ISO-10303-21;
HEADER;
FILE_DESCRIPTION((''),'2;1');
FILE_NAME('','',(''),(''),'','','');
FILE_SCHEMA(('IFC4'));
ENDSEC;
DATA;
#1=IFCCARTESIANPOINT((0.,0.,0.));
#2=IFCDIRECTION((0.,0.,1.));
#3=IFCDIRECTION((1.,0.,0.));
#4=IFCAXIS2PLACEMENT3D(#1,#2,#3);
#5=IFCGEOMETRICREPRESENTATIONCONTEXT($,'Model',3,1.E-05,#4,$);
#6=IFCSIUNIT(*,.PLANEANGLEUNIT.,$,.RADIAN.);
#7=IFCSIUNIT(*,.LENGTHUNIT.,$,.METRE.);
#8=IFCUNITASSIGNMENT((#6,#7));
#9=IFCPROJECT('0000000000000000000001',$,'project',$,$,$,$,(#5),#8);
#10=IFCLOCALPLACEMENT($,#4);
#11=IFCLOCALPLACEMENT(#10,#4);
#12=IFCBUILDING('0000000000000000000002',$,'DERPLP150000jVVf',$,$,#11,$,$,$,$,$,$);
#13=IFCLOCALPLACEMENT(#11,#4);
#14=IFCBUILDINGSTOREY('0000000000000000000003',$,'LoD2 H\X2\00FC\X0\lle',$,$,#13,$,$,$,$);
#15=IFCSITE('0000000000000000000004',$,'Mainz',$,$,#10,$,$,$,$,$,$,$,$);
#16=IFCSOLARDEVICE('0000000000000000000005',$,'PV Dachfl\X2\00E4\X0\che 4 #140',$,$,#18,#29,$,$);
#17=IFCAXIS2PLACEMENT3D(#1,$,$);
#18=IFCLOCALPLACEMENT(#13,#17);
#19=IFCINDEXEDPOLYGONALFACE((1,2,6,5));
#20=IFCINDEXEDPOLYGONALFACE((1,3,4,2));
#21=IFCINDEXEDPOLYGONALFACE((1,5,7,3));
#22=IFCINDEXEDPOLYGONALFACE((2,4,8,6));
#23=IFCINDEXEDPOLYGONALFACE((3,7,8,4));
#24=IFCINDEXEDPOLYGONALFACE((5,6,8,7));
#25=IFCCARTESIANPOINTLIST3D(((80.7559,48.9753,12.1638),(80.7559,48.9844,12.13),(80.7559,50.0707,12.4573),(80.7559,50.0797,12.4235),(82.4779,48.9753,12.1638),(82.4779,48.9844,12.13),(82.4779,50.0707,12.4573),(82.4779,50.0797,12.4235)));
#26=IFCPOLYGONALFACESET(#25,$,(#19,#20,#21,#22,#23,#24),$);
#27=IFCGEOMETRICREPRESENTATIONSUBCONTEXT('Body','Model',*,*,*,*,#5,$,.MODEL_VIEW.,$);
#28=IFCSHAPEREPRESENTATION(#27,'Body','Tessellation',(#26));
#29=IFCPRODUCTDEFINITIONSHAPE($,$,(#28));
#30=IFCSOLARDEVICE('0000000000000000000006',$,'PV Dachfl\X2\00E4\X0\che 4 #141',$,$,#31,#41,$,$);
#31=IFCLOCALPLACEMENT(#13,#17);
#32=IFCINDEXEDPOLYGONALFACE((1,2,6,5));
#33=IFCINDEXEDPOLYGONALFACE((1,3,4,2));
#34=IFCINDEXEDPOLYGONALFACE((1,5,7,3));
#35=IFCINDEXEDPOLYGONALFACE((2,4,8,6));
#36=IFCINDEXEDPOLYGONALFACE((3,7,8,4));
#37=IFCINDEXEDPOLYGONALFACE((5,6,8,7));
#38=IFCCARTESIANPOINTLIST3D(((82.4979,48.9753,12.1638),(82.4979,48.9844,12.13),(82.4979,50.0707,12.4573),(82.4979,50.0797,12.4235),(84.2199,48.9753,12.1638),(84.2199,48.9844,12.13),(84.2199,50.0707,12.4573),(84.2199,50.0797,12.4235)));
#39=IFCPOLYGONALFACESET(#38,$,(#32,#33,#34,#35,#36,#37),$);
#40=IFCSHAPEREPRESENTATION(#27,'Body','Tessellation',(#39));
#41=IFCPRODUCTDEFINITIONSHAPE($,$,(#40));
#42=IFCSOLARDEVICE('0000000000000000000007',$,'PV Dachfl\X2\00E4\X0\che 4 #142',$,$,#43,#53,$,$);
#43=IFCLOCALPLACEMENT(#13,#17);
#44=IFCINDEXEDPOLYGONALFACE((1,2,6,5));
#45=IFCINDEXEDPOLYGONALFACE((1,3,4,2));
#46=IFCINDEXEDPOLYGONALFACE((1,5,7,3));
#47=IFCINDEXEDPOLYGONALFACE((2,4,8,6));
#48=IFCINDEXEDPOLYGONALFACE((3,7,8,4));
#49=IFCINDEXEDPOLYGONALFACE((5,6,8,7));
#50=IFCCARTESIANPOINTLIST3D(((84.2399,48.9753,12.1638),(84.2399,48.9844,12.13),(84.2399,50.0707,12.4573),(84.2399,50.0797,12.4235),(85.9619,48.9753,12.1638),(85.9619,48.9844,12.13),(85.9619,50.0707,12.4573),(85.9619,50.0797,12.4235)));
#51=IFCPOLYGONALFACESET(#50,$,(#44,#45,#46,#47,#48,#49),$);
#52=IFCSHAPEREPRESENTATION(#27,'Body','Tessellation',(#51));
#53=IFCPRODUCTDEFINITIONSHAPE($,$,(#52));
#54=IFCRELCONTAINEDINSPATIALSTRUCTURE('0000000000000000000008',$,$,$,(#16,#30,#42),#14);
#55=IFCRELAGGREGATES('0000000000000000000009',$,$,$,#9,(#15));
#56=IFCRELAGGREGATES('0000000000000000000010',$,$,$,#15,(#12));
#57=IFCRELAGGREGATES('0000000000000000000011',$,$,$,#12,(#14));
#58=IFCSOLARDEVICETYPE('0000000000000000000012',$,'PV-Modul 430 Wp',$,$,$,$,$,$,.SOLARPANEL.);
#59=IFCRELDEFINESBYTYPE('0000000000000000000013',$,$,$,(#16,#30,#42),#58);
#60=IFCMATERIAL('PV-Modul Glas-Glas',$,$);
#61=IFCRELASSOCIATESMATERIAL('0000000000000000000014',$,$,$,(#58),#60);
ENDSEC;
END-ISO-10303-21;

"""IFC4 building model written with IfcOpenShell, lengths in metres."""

from ifc_helpers import new_model, si_unit, frame, frame_2d, origin, origin_with_axes, place, context, subcontext, project, spatial, rectangle, extrude, source, transform, mapped, material, type_object, type_shapes, element, save


model = new_model("IFC4")

# Units and contexts
model_context = context("Model", 3, precision=1e-05, world=origin_with_axes())
body_context = subcontext(model_context, "Body", "Model", "MODEL_VIEW")
ifc_project = project(units=[si_unit("PLANEANGLEUNIT", "RADIAN"), si_unit("LENGTHUNIT", "METRE")], contexts=[model_context])

# Site, building, storey
site_placement = place(None, origin_with_axes())
site = spatial("IfcSite", under=ifc_project, at=site_placement, Name="Mainz")
building_placement = place(site_placement, origin_with_axes())
building = spatial("IfcBuilding", under=site, at=building_placement, Name="DERPLP150000jVVf")
storey_placement = place(building_placement, origin_with_axes())
storey = spatial("IfcBuildingStorey", under=building, at=storey_placement, Name="LoD2 Hülle")

# Solar devices
ifc_material = material(Name="PV-Modul Glas-Glas")
solar_device_type = type_object("IfcSolarDeviceType", Name="PV-Modul 430 Wp", PredefinedType="SOLARPANEL", material=ifc_material)
shared_shape = source(origin_with_axes(), body_context, "Body", "SweptSolid", [
    extrude(rectangle(XDim=1.722, YDim=1.134, at=frame_2d((0.861, 0.567))), origin(), (0.0, 0.0, 1.0), 0.035),
])
type_shapes(solar_device_type, [shared_shape])
for number, where, z_axis, x_axis, name in (
    (1, (80.7559, 48.9844, 12.13), (0.0, -0.258819, 0.965926), (1.0, 0.0, 0.0), "PV Dachfläche 4 #140"),
    (2, (82.4979, 48.9844, 12.13), (0.0, -0.258819, 0.965926), (1.0, 0.0, 0.0), "PV Dachfläche 4 #141"),
    (3, (84.2399, 48.9844, 12.13), (0.0, -0.258819, 0.965926), (1.0, 0.0, 0.0), "PV Dachfläche 4 #142"),
):
    element("IfcSolarDevice", number, at=place(storey_placement, frame(where, z_axis=z_axis, x_axis=x_axis)), inside=storey, type_object=solar_device_type, Name=name, context=body_context, shape_type="MappedRepresentation", body=[
        mapped(shared_shape, transform((0.0, 0.0, 0.0), x_axis=(1.0, 0.0, 0.0), y_axis=(0.0, 1.0, 0.0), z_axis=(0.0, 0.0, 1.0), scale=1.0)),
    ])

save(model, "model.ifc")
